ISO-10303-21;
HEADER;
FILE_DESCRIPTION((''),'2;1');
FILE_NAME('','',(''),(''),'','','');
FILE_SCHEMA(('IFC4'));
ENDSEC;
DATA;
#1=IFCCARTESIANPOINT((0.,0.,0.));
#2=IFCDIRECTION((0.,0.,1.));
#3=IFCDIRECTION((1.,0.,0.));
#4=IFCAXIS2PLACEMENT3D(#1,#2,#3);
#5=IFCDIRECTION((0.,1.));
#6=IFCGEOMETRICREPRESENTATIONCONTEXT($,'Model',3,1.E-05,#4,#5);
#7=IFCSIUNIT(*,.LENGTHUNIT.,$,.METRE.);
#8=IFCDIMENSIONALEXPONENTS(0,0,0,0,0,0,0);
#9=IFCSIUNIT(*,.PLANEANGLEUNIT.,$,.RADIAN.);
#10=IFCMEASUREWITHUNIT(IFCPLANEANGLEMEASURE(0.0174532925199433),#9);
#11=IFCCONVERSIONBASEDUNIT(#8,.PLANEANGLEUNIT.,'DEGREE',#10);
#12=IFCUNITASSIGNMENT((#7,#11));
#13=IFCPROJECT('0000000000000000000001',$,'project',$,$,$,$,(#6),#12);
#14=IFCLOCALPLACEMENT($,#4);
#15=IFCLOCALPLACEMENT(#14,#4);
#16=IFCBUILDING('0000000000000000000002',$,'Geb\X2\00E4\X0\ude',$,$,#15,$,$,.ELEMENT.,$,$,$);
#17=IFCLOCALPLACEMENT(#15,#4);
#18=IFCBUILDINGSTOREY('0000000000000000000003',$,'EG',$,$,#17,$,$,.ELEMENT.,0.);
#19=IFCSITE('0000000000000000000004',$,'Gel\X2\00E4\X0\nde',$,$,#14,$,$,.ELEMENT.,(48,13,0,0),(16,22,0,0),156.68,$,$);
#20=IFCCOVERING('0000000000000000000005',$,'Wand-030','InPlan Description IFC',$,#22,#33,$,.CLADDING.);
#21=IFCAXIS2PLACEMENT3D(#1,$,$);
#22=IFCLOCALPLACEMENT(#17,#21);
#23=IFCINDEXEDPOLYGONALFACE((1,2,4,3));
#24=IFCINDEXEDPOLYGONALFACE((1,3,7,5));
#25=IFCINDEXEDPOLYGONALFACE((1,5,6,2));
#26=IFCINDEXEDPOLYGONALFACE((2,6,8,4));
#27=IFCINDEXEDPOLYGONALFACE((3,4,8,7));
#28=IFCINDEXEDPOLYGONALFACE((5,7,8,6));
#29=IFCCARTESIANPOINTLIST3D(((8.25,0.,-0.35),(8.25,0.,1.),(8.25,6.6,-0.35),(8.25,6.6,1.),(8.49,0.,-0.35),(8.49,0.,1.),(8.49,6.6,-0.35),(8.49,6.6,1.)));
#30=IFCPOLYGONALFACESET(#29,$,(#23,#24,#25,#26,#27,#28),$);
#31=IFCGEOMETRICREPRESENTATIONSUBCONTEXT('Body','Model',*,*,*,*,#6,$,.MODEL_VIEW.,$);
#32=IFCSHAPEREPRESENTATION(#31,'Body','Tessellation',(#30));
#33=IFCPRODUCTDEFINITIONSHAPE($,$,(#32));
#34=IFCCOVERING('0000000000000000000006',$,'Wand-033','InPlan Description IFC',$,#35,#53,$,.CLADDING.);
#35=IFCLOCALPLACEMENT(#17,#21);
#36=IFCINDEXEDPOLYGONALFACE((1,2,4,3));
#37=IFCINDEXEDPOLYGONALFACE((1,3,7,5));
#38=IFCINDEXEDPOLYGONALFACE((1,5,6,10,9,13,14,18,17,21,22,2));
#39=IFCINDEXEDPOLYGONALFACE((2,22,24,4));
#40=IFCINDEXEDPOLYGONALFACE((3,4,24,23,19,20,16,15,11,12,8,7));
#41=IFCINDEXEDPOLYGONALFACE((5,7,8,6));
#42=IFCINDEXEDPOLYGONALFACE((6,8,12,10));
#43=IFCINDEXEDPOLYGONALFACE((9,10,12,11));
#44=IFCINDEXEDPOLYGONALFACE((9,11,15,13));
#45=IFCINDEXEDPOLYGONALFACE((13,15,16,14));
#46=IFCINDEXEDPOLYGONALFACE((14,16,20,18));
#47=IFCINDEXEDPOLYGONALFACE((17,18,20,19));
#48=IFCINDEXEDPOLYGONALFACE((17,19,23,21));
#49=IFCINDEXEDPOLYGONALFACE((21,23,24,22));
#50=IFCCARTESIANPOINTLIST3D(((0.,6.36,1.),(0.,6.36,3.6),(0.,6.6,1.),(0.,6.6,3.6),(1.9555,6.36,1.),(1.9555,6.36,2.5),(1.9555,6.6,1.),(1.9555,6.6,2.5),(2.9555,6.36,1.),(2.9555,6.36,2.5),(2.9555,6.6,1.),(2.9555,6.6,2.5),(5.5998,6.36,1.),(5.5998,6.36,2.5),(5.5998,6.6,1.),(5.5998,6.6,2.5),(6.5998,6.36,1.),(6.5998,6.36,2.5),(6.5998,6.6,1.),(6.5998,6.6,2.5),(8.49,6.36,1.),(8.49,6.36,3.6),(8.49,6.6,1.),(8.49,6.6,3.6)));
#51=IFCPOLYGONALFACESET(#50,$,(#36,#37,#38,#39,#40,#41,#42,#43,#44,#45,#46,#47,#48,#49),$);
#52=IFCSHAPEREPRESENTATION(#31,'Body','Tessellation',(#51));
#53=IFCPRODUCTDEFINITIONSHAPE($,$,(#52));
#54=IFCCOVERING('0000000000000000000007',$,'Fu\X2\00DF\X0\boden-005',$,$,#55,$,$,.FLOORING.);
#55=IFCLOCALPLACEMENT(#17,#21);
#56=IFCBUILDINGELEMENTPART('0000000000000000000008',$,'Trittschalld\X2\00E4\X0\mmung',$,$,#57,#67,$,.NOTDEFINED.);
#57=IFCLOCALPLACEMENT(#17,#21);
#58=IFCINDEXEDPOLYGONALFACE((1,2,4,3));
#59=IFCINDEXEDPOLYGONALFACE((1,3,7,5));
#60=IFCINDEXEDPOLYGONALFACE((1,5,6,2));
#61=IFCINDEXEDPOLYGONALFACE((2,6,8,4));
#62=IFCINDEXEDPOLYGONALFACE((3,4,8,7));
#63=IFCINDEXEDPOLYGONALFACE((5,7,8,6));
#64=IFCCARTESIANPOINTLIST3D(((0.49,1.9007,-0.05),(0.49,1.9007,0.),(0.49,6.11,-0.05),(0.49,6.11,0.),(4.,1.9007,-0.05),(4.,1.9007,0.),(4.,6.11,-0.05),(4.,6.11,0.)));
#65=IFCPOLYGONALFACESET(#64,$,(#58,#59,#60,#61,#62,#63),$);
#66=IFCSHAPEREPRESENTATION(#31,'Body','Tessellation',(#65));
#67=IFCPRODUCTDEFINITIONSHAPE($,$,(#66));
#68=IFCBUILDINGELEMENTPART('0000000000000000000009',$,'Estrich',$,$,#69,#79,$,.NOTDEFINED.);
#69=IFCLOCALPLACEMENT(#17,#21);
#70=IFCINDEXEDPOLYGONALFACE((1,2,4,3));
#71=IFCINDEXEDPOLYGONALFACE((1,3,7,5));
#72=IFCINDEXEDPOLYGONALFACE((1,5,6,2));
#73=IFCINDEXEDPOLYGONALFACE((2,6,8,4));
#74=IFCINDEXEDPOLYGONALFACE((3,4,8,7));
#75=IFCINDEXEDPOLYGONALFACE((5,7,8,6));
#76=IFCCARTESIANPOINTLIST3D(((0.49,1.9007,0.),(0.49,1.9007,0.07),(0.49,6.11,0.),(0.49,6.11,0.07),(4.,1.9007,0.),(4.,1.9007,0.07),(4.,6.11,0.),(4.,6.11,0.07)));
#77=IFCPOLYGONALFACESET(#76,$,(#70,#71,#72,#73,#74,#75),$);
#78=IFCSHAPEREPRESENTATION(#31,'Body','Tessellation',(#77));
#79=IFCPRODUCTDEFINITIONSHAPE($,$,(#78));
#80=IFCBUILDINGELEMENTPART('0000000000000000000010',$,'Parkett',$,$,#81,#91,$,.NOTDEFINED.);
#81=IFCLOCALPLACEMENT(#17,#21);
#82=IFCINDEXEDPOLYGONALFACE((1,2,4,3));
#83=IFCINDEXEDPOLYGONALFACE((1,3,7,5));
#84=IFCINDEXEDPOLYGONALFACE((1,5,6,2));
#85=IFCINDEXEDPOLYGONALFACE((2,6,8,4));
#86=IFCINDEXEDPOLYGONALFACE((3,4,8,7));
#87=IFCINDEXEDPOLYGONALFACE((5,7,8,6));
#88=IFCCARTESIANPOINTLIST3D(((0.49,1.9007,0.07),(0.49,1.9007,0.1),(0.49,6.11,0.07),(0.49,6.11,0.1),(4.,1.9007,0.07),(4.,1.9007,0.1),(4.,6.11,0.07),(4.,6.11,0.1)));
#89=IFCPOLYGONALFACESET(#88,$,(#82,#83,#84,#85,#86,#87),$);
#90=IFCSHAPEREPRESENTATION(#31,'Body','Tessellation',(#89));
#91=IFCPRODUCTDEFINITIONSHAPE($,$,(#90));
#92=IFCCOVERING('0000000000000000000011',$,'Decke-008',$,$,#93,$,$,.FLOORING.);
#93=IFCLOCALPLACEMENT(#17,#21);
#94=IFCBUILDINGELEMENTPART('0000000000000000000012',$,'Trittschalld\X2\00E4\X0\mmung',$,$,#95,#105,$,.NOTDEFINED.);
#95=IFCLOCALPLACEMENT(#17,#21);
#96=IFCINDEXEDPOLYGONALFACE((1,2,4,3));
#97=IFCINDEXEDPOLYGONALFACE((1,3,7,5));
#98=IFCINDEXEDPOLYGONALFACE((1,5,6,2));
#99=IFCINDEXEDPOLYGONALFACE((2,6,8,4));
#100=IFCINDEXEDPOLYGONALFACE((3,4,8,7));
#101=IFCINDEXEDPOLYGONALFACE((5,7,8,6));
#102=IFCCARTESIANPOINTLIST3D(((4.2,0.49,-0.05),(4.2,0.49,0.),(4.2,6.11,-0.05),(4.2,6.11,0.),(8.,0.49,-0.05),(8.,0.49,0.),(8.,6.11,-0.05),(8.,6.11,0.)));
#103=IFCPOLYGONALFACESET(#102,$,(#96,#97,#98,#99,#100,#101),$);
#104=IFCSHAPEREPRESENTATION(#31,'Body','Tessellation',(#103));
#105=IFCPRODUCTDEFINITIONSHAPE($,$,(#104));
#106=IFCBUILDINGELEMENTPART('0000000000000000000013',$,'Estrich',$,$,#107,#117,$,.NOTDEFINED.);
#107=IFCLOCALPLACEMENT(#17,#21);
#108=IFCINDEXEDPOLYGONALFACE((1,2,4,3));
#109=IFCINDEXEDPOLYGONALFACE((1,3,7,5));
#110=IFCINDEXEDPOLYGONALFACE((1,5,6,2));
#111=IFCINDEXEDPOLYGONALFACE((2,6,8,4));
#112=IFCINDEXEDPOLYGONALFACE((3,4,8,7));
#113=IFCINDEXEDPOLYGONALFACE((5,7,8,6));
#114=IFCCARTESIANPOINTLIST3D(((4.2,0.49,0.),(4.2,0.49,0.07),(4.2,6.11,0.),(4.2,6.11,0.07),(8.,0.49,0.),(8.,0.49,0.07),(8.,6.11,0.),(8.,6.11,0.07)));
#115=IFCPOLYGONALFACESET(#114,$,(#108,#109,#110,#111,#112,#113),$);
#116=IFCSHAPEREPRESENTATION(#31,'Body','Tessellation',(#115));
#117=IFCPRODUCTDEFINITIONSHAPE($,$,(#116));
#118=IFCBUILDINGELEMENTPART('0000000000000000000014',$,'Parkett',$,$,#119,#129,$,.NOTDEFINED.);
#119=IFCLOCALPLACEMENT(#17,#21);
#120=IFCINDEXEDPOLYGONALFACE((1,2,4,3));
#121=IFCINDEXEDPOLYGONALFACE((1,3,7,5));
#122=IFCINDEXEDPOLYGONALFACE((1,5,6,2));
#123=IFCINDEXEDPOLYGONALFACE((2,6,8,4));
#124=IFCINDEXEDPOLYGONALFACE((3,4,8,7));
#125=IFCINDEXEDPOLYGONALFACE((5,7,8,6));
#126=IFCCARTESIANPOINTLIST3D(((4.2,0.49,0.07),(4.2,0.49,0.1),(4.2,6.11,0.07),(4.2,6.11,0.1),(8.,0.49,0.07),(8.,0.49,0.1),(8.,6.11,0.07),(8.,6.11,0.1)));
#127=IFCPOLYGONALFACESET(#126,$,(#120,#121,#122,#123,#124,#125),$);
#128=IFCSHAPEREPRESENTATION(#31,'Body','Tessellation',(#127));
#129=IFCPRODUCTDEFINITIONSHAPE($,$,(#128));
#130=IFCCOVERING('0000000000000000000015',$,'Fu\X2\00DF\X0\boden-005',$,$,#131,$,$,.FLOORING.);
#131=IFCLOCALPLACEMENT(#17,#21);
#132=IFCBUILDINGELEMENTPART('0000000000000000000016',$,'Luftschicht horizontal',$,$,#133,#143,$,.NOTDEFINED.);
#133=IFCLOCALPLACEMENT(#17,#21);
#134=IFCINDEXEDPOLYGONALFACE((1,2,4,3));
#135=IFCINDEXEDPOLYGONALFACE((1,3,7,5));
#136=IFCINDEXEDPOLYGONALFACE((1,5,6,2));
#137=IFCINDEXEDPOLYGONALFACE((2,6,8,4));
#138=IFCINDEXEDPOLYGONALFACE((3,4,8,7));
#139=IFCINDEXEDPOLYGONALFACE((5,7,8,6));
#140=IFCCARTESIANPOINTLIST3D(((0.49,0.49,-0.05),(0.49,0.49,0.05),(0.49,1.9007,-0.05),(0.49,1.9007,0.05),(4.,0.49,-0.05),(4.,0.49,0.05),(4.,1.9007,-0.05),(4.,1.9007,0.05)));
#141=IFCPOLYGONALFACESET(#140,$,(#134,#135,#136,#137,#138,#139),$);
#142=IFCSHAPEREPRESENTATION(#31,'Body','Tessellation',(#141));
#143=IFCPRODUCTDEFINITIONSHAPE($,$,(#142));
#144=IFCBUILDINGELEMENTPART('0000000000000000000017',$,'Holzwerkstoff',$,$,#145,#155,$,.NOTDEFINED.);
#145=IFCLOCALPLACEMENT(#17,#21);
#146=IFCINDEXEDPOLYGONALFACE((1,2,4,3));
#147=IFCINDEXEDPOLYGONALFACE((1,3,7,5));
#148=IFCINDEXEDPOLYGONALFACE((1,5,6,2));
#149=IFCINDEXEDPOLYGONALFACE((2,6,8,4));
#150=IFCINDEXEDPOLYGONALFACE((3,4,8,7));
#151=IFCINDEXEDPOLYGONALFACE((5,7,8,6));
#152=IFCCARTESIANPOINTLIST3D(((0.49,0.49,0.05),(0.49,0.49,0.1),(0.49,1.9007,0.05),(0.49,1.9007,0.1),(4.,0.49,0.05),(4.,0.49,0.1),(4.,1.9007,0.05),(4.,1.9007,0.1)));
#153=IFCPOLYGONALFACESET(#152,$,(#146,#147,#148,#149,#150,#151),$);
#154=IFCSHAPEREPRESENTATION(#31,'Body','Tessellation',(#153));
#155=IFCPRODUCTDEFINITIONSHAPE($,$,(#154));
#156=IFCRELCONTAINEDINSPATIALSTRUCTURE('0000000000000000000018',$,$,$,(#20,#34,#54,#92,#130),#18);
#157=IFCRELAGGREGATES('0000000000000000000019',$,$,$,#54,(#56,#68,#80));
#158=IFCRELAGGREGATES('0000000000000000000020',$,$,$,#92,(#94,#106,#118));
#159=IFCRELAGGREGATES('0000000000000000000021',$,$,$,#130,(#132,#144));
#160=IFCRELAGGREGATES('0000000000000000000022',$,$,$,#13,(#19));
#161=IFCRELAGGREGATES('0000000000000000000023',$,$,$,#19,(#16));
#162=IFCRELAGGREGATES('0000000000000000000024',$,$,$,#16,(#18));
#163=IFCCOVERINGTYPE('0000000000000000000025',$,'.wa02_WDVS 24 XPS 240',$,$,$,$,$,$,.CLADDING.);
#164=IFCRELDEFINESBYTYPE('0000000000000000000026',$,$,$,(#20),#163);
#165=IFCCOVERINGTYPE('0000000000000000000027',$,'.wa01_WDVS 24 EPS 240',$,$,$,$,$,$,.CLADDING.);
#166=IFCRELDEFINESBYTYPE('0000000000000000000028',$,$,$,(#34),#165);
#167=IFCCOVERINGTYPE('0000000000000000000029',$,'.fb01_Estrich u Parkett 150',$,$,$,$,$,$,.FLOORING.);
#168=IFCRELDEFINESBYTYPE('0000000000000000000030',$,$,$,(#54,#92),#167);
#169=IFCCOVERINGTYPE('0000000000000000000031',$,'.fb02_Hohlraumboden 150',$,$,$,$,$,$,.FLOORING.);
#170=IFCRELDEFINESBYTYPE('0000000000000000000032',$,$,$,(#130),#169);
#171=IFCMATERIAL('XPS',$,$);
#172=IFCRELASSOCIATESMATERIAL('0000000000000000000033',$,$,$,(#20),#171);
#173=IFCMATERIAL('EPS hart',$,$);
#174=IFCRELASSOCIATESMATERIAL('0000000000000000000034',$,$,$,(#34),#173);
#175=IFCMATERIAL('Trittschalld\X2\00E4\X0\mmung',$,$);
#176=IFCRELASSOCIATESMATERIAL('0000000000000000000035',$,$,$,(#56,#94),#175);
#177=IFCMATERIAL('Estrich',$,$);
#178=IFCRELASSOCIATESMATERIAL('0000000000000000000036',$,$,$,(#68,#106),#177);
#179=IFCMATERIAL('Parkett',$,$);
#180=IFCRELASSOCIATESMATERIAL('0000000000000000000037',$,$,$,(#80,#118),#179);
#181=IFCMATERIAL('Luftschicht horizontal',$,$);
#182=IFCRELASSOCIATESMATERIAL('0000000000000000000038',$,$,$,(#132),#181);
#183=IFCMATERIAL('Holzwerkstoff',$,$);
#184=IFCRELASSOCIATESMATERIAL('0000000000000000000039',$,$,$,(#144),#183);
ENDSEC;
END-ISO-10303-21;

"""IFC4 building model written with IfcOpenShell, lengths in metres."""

from ifc_helpers import new_model, entity, si_unit, converted_unit, direction, frame, origin_with_axes, origin_2d_with_axis, place, context, subcontext, project, spatial, line, indexed_curve, rectangle, outline, extrude, material, material_profile, profile_set, type_object, element, aggregate, save


model = new_model("IFC4")

# Units and contexts
model_context = context("Model", 3, precision=1e-05, world=origin_with_axes(), true_north=direction((0.0, 1.0)))
body_context = subcontext(model_context, "Body", "Model", "MODEL_VIEW")
ifc_project = project(units=[si_unit("LENGTHUNIT", "METRE"), converted_unit("PLANEANGLEUNIT", "DEGREE", entity("IfcPlaneAngleMeasure", 0.0174532925199433), si_unit("PLANEANGLEUNIT", "RADIAN"), dimensions=[0, 0, 0, 0, 0, 0, 0])], contexts=[model_context])

# Site, building, storey
site_placement = place(None, origin_with_axes())
site = spatial("IfcSite", under=ifc_project, at=site_placement, Name="Gelände", CompositionType="ELEMENT", RefLatitude=(48, 13, 0, 0), RefLongitude=(16, 22, 0, 0), RefElevation=156.68)
building_placement = place(site_placement, origin_with_axes())
building = spatial("IfcBuilding", under=site, at=building_placement, Name="Gebäude", CompositionType="ELEMENT")
storey_placement = place(building_placement, origin_with_axes())
storey = spatial("IfcBuildingStorey", under=building, at=storey_placement, Name="EG", CompositionType="ELEMENT", Elevation=0.0)

# Covering
ifc_material_1 = material(Name="XPS")
ifc_material_profile_1 = material_profile(ifc_material_1, outline(indexed_curve([(0.0, 0.0), (6.6, 0.0), (6.6, 0.24), (0.0, 0.24)], segments=[line(1, 2, 3, 4, 1)])), Name="XPS")
ifc_profile_set_1 = profile_set([ifc_material_profile_1], Name=".wa02_WDVS 24 XPS (240 x 6600)")
covering_type_1 = type_object("IfcCoveringType", Name=".wa02_WDVS 24 XPS 240", PredefinedType="CLADDING")
covering_1_placement = place(storey_placement, frame((8.49, 0.0, -0.35), z_axis=(0.0, 0.0, 1.0), x_axis=(0.0, 1.0, 0.0)))
element("IfcCovering", 1, at=covering_1_placement, inside=storey, type_object=covering_type_1, material=ifc_profile_set_1, Name="Wand-030", Description="InPlan Description IFC", PredefinedType="CLADDING", context=body_context, shape_type="SweptSolid", body=[
    extrude(outline(indexed_curve([(0.0, 0.0), (6.6, 0.0), (6.6, 0.24), (0.0, 0.24)], segments=[line(1, 2, 3, 4, 1)])), origin_with_axes(), (0.0, 0.0, 1.0), 1.35),
])

# Covering, openings
ifc_material_2 = material(Name="EPS hart")
ifc_material_profile_2 = material_profile(ifc_material_2, outline(indexed_curve([(0.0, 0.0), (8.49, 0.0), (8.49, 0.24), (0.0, 0.24)], segments=[line(1, 2, 3, 4, 1)])), Name="EPS hart")
ifc_profile_set_2 = profile_set([ifc_material_profile_2], Name=".wa01_WDVS 24 EPS (240 x 8490)")
covering_type_2 = type_object("IfcCoveringType", Name=".wa01_WDVS 24 EPS 240", PredefinedType="CLADDING")
covering_2_placement = place(storey_placement, frame((8.49, 6.6, 1.0), z_axis=(0.0, 0.0, 1.0), x_axis=(-1.0, 0.0, 0.0)))
covering_2 = element("IfcCovering", 2, at=covering_2_placement, inside=storey, type_object=covering_type_2, material=ifc_profile_set_2, Name="Wand-033", Description="InPlan Description IFC", PredefinedType="CLADDING", context=body_context, shape_type="SweptSolid", body=[
    extrude(outline(indexed_curve([(0.0, 0.0), (8.49, 0.0), (8.49, 0.24), (0.0, 0.24)], segments=[line(1, 2, 3, 4, 1)])), origin_with_axes(), (0.0, 0.0, 1.0), 2.6),
])
opening_1_placement = place(covering_2_placement, frame((2.3902, 0.0, 0.0), z_axis=(0.0, 0.0, 1.0), x_axis=(1.0, 0.0, 0.0)))
element("IfcOpeningElement", 3, at=opening_1_placement, cuts=covering_2, context=body_context, shape_type="SweptSolid", body=[
    extrude(rectangle(XDim=1.0, YDim=1.5, at=origin_2d_with_axis()), frame((0.0, 0.0, 0.75), z_axis=(0.0, 1.0, 0.0), x_axis=(1.0, 0.0, 0.0)), (0.0, 0.0, -1.0), 0.24),
    extrude(rectangle(XDim=1.0, YDim=1.5, at=origin_2d_with_axis()), frame((0.0, 0.0, 0.75), z_axis=(0.0, -1.0, 0.0), x_axis=(1.0, 0.0, 0.0)), (0.0, 0.0, -1.0), 0.24),
])
opening_2_placement = place(covering_2_placement, frame((6.0345, 0.0, 0.0), z_axis=(0.0, 0.0, 1.0), x_axis=(1.0, 0.0, 0.0)))
element("IfcOpeningElement", 4, at=opening_2_placement, cuts=covering_2, context=body_context, shape_type="SweptSolid", body=[
    extrude(rectangle(XDim=1.0, YDim=1.5, at=origin_2d_with_axis()), frame((0.0, 0.0, 0.75), z_axis=(0.0, 1.0, 0.0), x_axis=(1.0, 0.0, 0.0)), (0.0, 0.0, -1.0), 0.24),
    extrude(rectangle(XDim=1.0, YDim=1.5, at=origin_2d_with_axis()), frame((0.0, 0.0, 0.75), z_axis=(0.0, -1.0, 0.0), x_axis=(1.0, 0.0, 0.0)), (0.0, 0.0, -1.0), 0.24),
])

# Coverings, building element parts
covering_type_3 = type_object("IfcCoveringType", Name=".fb01_Estrich u Parkett 150", PredefinedType="FLOORING")
covering_3_placement = place(storey_placement, frame((0.49, 1.9007, 0.1), z_axis=(0.0, 0.0, 1.0), x_axis=(1.0, 0.0, 0.0)))
covering_3 = element("IfcCovering", 5, at=covering_3_placement, inside=storey, type_object=covering_type_3, Name="Fußboden-005", PredefinedType="FLOORING")
ifc_material_3 = material(Name="Trittschalldämmung")
building_element_part_1_placement = place(covering_3_placement, origin_with_axes())
building_element_part_1 = element("IfcBuildingElementPart", 6, at=building_element_part_1_placement, material=ifc_material_3, Name="Trittschalldämmung", PredefinedType="NOTDEFINED", context=body_context, shape_type="SweptSolid", body=[
    extrude(outline(indexed_curve([(0.0, 0.0), (3.51, 0.0), (3.51, 4.2093), (0.0, 4.2093)], segments=[line(1, 2, 3, 4, 1)])), frame((0.0, 0.0, -0.15), z_axis=(0.0, 0.0, 1.0), x_axis=(1.0, 0.0, 0.0)), (0.0, 0.0, 1.0), 0.05),
])
ifc_material_4 = material(Name="Estrich")
building_element_part_2_placement = place(covering_3_placement, origin_with_axes())
building_element_part_2 = element("IfcBuildingElementPart", 7, at=building_element_part_2_placement, material=ifc_material_4, Name="Estrich", PredefinedType="NOTDEFINED", context=body_context, shape_type="SweptSolid", body=[
    extrude(outline(indexed_curve([(0.0, 0.0), (3.51, 0.0), (3.51, 4.2093), (0.0, 4.2093)], segments=[line(1, 2, 3, 4, 1)])), frame((0.0, 0.0, -0.1), z_axis=(0.0, 0.0, 1.0), x_axis=(1.0, 0.0, 0.0)), (0.0, 0.0, 1.0), 0.07),
])
ifc_material_5 = material(Name="Parkett")
building_element_part_3_placement = place(covering_3_placement, origin_with_axes())
building_element_part_3 = element("IfcBuildingElementPart", 8, at=building_element_part_3_placement, material=ifc_material_5, Name="Parkett", PredefinedType="NOTDEFINED", context=body_context, shape_type="SweptSolid", body=[
    extrude(outline(indexed_curve([(0.0, 0.0), (3.51, 0.0), (3.51, 4.2093), (0.0, 4.2093)], segments=[line(1, 2, 3, 4, 1)])), frame((0.0, 0.0, -0.03), z_axis=(0.0, 0.0, 1.0), x_axis=(1.0, 0.0, 0.0)), (0.0, 0.0, 1.0), 0.03),
])
aggregate(covering_3, [building_element_part_1, building_element_part_2, building_element_part_3])
covering_4_placement = place(storey_placement, frame((4.2, 0.49, 0.1), z_axis=(0.0, 0.0, 1.0), x_axis=(1.0, 0.0, 0.0)))
covering_4 = element("IfcCovering", 9, at=covering_4_placement, inside=storey, type_object=covering_type_3, Name="Decke-008", PredefinedType="FLOORING")
building_element_part_4_placement = place(covering_4_placement, origin_with_axes())
building_element_part_4 = element("IfcBuildingElementPart", 10, at=building_element_part_4_placement, material=ifc_material_3, Name="Trittschalldämmung", PredefinedType="NOTDEFINED", context=body_context, shape_type="SweptSolid", body=[
    extrude(outline(indexed_curve([(0.0, 0.0), (3.8, 0.0), (3.8, 5.62), (0.0, 5.62)], segments=[line(1, 2, 3, 4, 1)])), frame((0.0, 0.0, -0.15), z_axis=(0.0, 0.0, 1.0), x_axis=(1.0, 0.0, 0.0)), (0.0, 0.0, 1.0), 0.05),
])
building_element_part_5_placement = place(covering_4_placement, origin_with_axes())
building_element_part_5 = element("IfcBuildingElementPart", 11, at=building_element_part_5_placement, material=ifc_material_4, Name="Estrich", PredefinedType="NOTDEFINED", context=body_context, shape_type="SweptSolid", body=[
    extrude(outline(indexed_curve([(0.0, 0.0), (3.8, 0.0), (3.8, 5.62), (0.0, 5.62)], segments=[line(1, 2, 3, 4, 1)])), frame((0.0, 0.0, -0.1), z_axis=(0.0, 0.0, 1.0), x_axis=(1.0, 0.0, 0.0)), (0.0, 0.0, 1.0), 0.07),
])
building_element_part_6_placement = place(covering_4_placement, origin_with_axes())
building_element_part_6 = element("IfcBuildingElementPart", 12, at=building_element_part_6_placement, material=ifc_material_5, Name="Parkett", PredefinedType="NOTDEFINED", context=body_context, shape_type="SweptSolid", body=[
    extrude(outline(indexed_curve([(0.0, 0.0), (3.8, 0.0), (3.8, 5.62), (0.0, 5.62)], segments=[line(1, 2, 3, 4, 1)])), frame((0.0, 0.0, -0.03), z_axis=(0.0, 0.0, 1.0), x_axis=(1.0, 0.0, 0.0)), (0.0, 0.0, 1.0), 0.03),
])
aggregate(covering_4, [building_element_part_4, building_element_part_5, building_element_part_6])
covering_type_4 = type_object("IfcCoveringType", Name=".fb02_Hohlraumboden 150", PredefinedType="FLOORING")
covering_5_placement = place(storey_placement, frame((0.49, 0.49, 0.1), z_axis=(0.0, 0.0, 1.0), x_axis=(1.0, 0.0, 0.0)))
covering_5 = element("IfcCovering", 13, at=covering_5_placement, inside=storey, type_object=covering_type_4, Name="Fußboden-005", PredefinedType="FLOORING")
ifc_material_6 = material(Name="Luftschicht horizontal")
building_element_part_7_placement = place(covering_5_placement, origin_with_axes())
building_element_part_7 = element("IfcBuildingElementPart", 14, at=building_element_part_7_placement, material=ifc_material_6, Name="Luftschicht horizontal", PredefinedType="NOTDEFINED", context=body_context, shape_type="SweptSolid", body=[
    extrude(outline(indexed_curve([(0.0, 0.0), (3.51, 0.0), (3.51, 1.4107), (0.0, 1.4107)], segments=[line(1, 2, 3, 4, 1)])), frame((0.0, 0.0, -0.15), z_axis=(0.0, 0.0, 1.0), x_axis=(1.0, 0.0, 0.0)), (0.0, 0.0, 1.0), 0.1),
])
ifc_material_7 = material(Name="Holzwerkstoff")
building_element_part_8_placement = place(covering_5_placement, origin_with_axes())
building_element_part_8 = element("IfcBuildingElementPart", 15, at=building_element_part_8_placement, material=ifc_material_7, Name="Holzwerkstoff", PredefinedType="NOTDEFINED", context=body_context, shape_type="SweptSolid", body=[
    extrude(outline(indexed_curve([(0.0, 0.0), (3.51, 0.0), (3.51, 1.4107), (0.0, 1.4107)], segments=[line(1, 2, 3, 4, 1)])), frame((0.0, 0.0, -0.05), z_axis=(0.0, 0.0, 1.0), x_axis=(1.0, 0.0, 0.0)), (0.0, 0.0, 1.0), 0.05),
])
aggregate(covering_5, [building_element_part_7, building_element_part_8])

save(model, "model.ifc")
